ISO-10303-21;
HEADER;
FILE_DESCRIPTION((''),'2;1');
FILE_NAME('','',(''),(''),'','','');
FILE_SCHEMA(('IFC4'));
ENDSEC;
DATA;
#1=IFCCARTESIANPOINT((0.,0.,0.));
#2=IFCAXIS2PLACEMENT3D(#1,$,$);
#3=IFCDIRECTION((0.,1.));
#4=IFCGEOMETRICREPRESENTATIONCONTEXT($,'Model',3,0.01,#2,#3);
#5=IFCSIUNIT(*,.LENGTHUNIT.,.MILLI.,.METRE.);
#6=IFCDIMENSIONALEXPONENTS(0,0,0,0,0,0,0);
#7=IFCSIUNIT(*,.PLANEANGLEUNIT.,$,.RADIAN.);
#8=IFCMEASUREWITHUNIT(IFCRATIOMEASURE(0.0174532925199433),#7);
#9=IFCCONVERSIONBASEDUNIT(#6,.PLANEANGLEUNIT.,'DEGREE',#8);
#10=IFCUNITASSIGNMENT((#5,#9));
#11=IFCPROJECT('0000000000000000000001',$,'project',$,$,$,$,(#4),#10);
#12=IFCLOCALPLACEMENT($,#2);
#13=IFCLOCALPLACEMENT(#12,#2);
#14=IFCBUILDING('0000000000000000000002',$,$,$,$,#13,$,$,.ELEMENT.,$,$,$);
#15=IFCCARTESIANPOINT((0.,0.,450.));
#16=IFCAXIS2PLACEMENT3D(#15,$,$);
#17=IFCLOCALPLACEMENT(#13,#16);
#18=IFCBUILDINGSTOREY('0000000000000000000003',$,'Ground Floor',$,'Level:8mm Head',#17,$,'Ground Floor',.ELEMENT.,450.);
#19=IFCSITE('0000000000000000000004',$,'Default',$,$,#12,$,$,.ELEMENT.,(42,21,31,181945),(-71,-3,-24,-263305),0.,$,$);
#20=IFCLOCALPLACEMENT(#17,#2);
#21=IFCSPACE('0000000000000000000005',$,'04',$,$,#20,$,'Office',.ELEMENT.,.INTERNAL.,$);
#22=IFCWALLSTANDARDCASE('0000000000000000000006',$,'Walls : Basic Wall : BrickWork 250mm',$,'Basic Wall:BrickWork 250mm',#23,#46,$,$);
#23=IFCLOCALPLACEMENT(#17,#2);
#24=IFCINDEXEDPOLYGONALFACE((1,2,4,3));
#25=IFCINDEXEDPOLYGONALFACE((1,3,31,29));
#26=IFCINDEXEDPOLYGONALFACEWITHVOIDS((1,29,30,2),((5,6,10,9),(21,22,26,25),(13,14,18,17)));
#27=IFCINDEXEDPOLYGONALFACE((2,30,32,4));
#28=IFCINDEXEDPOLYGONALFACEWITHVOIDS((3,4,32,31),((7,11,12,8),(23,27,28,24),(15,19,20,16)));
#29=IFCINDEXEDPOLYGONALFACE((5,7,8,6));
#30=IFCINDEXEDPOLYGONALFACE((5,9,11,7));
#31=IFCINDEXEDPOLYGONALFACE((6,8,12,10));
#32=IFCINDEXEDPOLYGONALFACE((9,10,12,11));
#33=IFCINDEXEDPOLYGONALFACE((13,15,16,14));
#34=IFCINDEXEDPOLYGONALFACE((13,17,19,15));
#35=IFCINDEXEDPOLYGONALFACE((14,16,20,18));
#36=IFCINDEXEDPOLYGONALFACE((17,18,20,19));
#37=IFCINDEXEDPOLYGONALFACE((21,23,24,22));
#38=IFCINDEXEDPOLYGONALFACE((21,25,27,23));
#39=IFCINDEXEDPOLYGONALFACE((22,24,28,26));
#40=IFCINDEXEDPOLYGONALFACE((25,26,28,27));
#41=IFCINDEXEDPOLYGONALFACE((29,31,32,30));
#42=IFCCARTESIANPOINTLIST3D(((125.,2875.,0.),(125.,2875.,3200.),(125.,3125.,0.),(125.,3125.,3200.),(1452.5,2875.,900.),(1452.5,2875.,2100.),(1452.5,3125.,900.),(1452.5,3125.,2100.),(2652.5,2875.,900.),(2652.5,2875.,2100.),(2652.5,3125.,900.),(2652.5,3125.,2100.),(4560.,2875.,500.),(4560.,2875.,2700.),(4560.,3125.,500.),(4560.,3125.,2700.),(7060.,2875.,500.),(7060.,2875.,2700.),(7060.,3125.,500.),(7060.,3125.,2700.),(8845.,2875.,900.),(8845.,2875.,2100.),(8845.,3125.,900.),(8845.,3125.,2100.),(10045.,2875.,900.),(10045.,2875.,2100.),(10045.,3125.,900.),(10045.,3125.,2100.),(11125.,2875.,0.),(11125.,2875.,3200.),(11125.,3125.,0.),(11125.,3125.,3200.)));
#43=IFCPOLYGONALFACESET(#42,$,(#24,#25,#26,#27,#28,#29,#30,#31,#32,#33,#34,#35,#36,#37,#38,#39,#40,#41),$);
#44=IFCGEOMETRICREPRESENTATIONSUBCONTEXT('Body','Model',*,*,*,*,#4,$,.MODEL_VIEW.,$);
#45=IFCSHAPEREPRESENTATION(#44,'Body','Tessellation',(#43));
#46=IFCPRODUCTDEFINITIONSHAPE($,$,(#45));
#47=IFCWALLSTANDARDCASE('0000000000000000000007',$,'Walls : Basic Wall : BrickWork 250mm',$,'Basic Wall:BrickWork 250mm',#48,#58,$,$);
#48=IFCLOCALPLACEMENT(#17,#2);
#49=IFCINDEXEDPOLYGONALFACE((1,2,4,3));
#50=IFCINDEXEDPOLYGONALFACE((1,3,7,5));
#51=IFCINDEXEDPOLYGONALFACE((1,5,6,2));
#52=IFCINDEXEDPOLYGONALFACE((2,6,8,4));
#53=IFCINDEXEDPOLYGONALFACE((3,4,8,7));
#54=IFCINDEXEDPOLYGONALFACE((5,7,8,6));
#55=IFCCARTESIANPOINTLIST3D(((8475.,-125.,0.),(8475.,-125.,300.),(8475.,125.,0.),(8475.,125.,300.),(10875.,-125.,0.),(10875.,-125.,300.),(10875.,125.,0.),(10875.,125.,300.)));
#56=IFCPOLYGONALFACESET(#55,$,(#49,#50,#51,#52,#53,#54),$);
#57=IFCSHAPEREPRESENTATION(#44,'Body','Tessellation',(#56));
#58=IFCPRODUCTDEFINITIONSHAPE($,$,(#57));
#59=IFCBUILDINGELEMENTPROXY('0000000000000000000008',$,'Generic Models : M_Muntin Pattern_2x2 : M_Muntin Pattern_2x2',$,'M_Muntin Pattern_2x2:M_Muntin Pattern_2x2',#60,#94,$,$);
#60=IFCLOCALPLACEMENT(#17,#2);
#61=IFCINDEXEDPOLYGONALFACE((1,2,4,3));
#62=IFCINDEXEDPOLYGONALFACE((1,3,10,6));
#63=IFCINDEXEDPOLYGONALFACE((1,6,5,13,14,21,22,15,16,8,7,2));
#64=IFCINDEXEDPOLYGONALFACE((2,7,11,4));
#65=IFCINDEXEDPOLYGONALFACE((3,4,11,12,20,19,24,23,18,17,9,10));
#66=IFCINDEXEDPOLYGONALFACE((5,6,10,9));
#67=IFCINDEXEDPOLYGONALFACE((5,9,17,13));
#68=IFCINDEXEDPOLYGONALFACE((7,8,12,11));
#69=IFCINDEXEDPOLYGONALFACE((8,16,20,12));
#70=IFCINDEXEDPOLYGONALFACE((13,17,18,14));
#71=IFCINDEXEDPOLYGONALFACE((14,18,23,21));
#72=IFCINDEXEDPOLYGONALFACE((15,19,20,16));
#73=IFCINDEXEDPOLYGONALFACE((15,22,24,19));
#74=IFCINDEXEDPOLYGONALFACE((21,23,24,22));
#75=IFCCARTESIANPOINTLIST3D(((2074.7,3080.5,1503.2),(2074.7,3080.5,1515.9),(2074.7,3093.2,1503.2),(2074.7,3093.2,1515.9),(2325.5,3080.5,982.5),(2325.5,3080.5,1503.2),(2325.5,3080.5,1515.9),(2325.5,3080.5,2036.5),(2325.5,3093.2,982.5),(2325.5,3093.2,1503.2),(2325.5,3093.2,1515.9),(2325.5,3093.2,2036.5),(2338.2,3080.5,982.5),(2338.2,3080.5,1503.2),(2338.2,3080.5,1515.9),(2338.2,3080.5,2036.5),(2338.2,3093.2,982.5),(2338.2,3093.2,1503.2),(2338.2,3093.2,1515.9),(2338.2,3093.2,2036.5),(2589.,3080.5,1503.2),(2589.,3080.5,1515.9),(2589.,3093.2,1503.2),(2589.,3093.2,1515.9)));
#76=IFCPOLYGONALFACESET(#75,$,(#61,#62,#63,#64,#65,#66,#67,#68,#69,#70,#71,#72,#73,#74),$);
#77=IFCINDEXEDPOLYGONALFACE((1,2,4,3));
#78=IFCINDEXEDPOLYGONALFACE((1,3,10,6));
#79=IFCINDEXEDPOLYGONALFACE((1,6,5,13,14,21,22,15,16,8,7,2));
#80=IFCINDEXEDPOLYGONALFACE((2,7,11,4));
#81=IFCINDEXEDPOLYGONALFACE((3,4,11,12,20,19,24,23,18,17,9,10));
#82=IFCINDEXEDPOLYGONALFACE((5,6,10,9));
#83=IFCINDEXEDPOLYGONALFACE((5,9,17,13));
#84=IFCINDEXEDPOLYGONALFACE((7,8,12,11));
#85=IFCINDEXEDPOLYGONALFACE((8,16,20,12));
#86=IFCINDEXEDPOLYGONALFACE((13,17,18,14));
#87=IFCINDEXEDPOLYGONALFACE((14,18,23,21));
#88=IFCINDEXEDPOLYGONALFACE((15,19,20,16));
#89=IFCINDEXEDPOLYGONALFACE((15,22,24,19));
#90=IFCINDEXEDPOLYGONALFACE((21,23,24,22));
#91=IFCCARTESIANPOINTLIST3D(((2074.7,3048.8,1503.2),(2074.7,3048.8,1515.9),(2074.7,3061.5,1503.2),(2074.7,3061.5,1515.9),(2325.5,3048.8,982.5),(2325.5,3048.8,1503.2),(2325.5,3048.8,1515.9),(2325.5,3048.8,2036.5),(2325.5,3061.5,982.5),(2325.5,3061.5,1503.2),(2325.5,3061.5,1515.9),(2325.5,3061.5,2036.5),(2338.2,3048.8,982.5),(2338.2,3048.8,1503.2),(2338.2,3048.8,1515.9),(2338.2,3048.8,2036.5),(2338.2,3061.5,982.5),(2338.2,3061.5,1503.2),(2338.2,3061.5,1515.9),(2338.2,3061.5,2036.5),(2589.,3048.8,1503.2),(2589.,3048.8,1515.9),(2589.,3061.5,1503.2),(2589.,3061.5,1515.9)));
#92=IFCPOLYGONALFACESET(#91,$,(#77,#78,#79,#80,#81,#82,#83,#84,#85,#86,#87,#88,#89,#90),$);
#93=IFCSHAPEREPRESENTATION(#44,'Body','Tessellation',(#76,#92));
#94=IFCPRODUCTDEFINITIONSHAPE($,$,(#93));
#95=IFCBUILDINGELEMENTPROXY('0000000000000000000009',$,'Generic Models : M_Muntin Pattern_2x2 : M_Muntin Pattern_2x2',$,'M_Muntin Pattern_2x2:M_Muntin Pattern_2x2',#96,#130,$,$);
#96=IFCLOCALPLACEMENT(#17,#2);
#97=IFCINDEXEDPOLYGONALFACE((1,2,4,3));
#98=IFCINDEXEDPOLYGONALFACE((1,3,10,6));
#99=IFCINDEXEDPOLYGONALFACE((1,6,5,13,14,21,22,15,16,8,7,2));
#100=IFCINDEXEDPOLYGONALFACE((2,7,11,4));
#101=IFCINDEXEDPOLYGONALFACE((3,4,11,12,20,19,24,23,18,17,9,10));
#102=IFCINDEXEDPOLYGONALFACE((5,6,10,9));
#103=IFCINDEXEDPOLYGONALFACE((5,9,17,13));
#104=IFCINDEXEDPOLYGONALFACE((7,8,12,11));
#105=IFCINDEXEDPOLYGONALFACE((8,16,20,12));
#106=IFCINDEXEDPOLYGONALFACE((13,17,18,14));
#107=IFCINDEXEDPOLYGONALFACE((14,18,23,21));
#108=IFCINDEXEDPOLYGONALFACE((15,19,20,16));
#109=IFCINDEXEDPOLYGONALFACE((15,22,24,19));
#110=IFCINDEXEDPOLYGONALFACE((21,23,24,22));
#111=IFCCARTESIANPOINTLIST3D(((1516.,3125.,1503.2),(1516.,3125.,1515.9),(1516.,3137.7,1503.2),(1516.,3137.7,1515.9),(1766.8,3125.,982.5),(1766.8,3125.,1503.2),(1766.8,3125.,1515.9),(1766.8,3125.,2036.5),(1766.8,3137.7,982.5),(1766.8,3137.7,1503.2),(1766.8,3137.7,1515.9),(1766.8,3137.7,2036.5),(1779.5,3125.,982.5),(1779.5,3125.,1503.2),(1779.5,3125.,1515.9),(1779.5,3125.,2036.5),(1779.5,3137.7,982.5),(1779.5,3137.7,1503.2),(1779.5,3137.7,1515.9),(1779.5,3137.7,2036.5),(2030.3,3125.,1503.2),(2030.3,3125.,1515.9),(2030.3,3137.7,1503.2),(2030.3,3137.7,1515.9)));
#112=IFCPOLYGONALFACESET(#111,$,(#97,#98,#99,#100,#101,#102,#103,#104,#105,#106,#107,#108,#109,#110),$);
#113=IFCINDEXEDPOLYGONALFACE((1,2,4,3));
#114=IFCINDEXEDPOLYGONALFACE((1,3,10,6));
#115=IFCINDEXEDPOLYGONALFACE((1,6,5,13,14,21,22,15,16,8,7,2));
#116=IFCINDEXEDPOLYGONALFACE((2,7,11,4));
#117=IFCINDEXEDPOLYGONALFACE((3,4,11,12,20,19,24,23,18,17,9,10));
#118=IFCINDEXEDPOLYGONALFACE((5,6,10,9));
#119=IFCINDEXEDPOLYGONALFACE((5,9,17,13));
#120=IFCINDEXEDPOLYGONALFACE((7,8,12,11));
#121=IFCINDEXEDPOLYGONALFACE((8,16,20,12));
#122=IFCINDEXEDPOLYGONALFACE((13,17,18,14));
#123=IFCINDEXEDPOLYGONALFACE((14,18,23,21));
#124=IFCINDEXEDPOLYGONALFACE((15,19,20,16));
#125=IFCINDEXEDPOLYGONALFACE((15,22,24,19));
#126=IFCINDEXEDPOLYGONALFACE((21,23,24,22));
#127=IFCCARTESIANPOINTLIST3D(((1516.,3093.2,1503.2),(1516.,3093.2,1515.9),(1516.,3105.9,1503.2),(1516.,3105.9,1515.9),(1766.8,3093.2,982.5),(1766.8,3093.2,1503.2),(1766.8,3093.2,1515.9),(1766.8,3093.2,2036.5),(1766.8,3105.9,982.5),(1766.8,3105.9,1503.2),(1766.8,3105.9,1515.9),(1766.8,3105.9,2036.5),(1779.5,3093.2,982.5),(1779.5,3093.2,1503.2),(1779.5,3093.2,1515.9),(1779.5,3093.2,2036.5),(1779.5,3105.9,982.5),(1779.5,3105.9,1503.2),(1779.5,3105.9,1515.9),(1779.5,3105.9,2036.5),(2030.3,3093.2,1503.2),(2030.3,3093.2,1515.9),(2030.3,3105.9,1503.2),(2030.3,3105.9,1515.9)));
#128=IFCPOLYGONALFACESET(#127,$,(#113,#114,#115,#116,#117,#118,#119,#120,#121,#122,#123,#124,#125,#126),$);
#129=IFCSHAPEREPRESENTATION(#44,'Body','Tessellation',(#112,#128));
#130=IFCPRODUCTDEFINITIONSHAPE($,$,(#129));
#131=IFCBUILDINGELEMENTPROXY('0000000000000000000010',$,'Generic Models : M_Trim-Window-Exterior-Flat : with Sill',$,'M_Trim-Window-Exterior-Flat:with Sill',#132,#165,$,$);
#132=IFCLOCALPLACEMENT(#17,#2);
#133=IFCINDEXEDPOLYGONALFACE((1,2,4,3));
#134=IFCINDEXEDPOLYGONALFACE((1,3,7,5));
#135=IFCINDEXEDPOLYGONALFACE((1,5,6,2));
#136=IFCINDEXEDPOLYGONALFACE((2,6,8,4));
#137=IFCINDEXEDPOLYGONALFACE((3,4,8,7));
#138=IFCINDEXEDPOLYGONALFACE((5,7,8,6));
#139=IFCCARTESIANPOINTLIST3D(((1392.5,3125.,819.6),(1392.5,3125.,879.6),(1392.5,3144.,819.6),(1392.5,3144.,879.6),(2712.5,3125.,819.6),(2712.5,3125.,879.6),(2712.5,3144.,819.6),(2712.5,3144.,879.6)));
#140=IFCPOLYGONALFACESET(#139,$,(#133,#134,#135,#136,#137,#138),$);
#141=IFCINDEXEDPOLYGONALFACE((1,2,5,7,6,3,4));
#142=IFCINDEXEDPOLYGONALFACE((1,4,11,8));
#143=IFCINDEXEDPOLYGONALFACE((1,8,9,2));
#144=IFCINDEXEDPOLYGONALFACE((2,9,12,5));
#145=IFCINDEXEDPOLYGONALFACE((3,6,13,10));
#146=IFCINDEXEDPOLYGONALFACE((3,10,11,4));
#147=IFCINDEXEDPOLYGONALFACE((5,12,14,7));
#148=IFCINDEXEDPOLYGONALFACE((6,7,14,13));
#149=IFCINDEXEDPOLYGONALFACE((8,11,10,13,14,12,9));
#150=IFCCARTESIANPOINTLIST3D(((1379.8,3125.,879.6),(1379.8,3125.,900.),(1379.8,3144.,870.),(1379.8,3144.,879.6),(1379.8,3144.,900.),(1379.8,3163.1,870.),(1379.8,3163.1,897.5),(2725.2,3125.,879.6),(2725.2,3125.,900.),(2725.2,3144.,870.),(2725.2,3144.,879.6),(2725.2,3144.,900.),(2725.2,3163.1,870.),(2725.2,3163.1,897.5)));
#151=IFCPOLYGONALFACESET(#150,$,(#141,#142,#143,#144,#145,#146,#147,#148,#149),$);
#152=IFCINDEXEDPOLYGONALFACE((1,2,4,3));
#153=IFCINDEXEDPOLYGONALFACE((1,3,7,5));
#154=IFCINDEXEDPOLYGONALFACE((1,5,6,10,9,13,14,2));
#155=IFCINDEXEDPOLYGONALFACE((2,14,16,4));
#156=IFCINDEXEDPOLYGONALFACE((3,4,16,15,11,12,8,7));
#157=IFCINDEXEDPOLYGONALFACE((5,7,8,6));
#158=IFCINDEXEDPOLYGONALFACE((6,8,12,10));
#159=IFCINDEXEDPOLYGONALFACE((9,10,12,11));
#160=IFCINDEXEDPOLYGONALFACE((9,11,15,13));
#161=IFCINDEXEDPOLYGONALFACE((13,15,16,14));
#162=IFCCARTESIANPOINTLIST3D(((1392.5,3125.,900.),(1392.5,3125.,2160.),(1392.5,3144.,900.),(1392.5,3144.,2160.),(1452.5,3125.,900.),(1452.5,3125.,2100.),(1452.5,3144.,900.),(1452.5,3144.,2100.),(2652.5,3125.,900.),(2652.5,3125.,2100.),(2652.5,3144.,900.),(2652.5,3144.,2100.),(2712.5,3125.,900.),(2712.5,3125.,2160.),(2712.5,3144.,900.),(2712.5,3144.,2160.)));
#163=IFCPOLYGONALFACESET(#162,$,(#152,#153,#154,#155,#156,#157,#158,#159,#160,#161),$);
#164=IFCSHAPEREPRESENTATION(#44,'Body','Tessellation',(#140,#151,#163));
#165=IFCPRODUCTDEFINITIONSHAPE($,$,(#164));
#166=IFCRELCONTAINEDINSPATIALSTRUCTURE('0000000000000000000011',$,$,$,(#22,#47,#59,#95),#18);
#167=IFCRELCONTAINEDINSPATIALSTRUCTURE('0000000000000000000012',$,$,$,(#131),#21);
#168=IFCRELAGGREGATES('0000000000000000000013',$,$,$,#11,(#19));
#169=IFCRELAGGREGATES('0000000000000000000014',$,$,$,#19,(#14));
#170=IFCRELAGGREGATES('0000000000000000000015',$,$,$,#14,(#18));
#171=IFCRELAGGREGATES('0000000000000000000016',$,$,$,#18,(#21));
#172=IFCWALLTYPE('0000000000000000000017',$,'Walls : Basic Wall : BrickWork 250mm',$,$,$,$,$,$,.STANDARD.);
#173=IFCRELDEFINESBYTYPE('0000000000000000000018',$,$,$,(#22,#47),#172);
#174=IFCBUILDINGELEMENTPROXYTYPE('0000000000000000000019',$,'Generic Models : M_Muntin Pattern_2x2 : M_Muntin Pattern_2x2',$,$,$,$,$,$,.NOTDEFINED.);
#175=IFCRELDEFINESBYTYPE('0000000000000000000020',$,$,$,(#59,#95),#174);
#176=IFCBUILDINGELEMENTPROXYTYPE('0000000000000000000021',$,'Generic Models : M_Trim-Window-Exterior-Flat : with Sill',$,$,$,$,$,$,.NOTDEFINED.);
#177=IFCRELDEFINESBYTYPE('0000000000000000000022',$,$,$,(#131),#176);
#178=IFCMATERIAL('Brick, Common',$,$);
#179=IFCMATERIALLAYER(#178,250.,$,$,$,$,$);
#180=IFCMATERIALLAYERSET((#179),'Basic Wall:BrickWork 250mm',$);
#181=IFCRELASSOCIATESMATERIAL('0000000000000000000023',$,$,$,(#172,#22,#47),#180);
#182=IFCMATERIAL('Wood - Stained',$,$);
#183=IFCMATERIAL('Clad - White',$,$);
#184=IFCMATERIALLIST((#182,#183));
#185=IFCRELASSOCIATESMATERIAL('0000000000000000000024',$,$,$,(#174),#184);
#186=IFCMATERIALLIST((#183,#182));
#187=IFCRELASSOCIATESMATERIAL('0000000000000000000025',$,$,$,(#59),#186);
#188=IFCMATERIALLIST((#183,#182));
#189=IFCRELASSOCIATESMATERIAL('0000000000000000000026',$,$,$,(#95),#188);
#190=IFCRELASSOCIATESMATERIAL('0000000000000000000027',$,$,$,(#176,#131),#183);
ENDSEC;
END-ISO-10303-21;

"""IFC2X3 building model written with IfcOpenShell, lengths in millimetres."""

from ifc_helpers import new_model, entity, si_unit, converted_unit, direction, frame, frame_2d, origin, place, context, subcontext, project, spatial, polyline, rectangle, outline, extrude, clip, halfspace, source, transform, mapped, material, material_list, layer, layer_set, layer_usage, type_object, type_shapes, element, save


model = new_model("IFC2X3")

# Units and contexts
model_context = context("Model", 3, precision=0.01, world=origin(), true_north=direction((0.0, 1.0)))
body_context = subcontext(model_context, "Body", "Model", "MODEL_VIEW")
ifc_project = project(units=[si_unit("LENGTHUNIT", "METRE", prefix="MILLI"), converted_unit("PLANEANGLEUNIT", "DEGREE", entity("IfcRatioMeasure", 0.0174532925199433), si_unit("PLANEANGLEUNIT", "RADIAN"), dimensions=[0, 0, 0, 0, 0, 0, 0])], contexts=[model_context])

# Site, building, storey
site_placement = place(None, origin())
site = spatial("IfcSite", under=ifc_project, at=site_placement, Name="Default", CompositionType="ELEMENT", RefLatitude=(42, 21, 31, 181945), RefLongitude=(-71, -3, -24, -263305), RefElevation=0.0)
building_placement = place(site_placement, origin())
building = spatial("IfcBuilding", under=site, at=building_placement, CompositionType="ELEMENT")
storey_placement = place(building_placement, frame((0.0, 0.0, 450.0)))
storey = spatial("IfcBuildingStorey", under=building, at=storey_placement, Name="Ground Floor", ObjectType="Level:8mm Head", LongName="Ground Floor", CompositionType="ELEMENT", Elevation=450.0)

# Shared definitions
ifc_material_1 = material(Name="Brick, Common")
ifc_layer = layer(ifc_material_1, 250.0)
ifc_layer_set = layer_set([ifc_layer], Name="Basic Wall:BrickWork 250mm")
wall_type = type_object("IfcWallType", Name="Walls : Basic Wall : BrickWork 250mm", PredefinedType="STANDARD", material=ifc_layer_set)

# Wall, openings
ifc_layer_usage_1 = layer_usage(ifc_layer_set, "AXIS2", "POSITIVE", -125.0)
wall_1_placement = place(storey_placement, frame((125.0, 3000.0, 0.0)))
wall_1 = element("IfcWallStandardCase", 1, at=wall_1_placement, inside=storey, type_object=wall_type, material=ifc_layer_usage_1, Name="Walls : Basic Wall : BrickWork 250mm", ObjectType="Basic Wall:BrickWork 250mm", context=body_context, shape_type="Clipping", body=[
    clip(extrude(rectangle(XDim=11000.0, YDim=250.0, at=frame_2d((5500.0, 0.0), x_axis=(-1.0, 0.0))), origin(), (0.0, 0.0, 1.0), 3200.0), halfspace(origin(), True)),
])
opening_1_placement = place(wall_1_placement, origin())
element("IfcOpeningElement", 2, at=opening_1_placement, cuts=wall_1, ObjectType="Opening", context=body_context, shape_type="SweptSolid", body=[
    extrude(rectangle(XDim=2200.0, YDim=2500.0, at=frame_2d((0.0, 0.0), x_axis=(1.0, 0.0))), frame((5685.0, -277.4, 1600.0), z_axis=(0.0, 1.0, 0.0), x_axis=(0.0, 0.0, 1.0)), (0.0, 0.0, 1.0), 554.8),
])
opening_2_placement = place(wall_1_placement, frame((1327.5, -125.0, 900.0)))
element("IfcOpeningElement", 3, at=opening_2_placement, cuts=wall_1, ObjectType="Opening", context=body_context, shape_type="SweptSolid", body=[
    extrude(rectangle(XDim=1200.0, YDim=1200.0, at=frame_2d((600.0, 600.0), x_axis=(-1.0, 0.0))), frame((0.0, 0.0, 0.0), z_axis=(0.0, 1.0, 0.0), x_axis=(0.0, 0.0, 1.0)), (0.0, 0.0, 1.0), 250.0),
])
opening_3_placement = place(wall_1_placement, frame((8720.0, -125.0, 900.0)))
element("IfcOpeningElement", 4, at=opening_3_placement, cuts=wall_1, ObjectType="Opening", context=body_context, shape_type="SweptSolid", body=[
    extrude(rectangle(XDim=1200.0, YDim=1200.0, at=frame_2d((600.0, 600.0), x_axis=(-1.0, 0.0))), frame((0.0, 0.0, 0.0), z_axis=(0.0, 1.0, 0.0), x_axis=(0.0, 0.0, 1.0)), (0.0, 0.0, 1.0), 250.0),
])

# Wall
ifc_layer_usage_2 = layer_usage(ifc_layer_set, "AXIS2", "NEGATIVE", 125.0)
wall_2_placement = place(storey_placement, frame((8475.0, 0.0, 0.0)))
element("IfcWallStandardCase", 5, at=wall_2_placement, inside=storey, type_object=wall_type, material=ifc_layer_usage_2, Name="Walls : Basic Wall : BrickWork 250mm", ObjectType="Basic Wall:BrickWork 250mm", context=body_context, shape_type="Clipping", body=[
    clip(extrude(rectangle(XDim=2400.0, YDim=250.0, at=frame_2d((1200.0, 0.0), x_axis=(-1.0, 0.0))), origin(), (0.0, 0.0, 1.0), 300.0), halfspace(frame((0.0, 0.0, -450.0)), True)),
])

# Building element proxies
ifc_material_2 = material(Name="Clad - White")
ifc_material_3 = material(Name="Wood - Stained")
ifc_material_list_1 = material_list([ifc_material_2, ifc_material_3])
ifc_material_list_2 = material_list([ifc_material_3, ifc_material_2])
building_element_proxy_type_1 = type_object("IfcBuildingElementProxyType", Name="Generic Models : M_Muntin Pattern_2x2 : M_Muntin Pattern_2x2", PredefinedType="NOTDEFINED", material=ifc_material_list_2)
shared_shape_1 = source(origin(), body_context, "Body", "SweptSolid", [
    extrude(outline(polyline([(6.4, -6.4), (527.0, -6.4), (527.0, 6.3), (6.4, 6.3), (6.4, 257.1), (-6.3, 257.1), (-6.3, 6.3), (-527.0, 6.3), (-527.0, -6.4), (-6.3, -6.4), (-6.3, -257.1), (6.4, -257.1), (6.4, -6.4)])), frame((0.0, 9.5, 527.0), z_axis=(0.0, 1.0, 0.0), x_axis=(0.0, 0.0, 1.0)), (0.0, 0.0, 1.0), 12.7),
    extrude(outline(polyline([(6.4, -6.4), (527.0, -6.4), (527.0, 6.3), (6.4, 6.3), (6.4, 257.1), (-6.3, 257.1), (-6.3, 6.3), (-527.0, 6.3), (-527.0, -6.4), (-6.3, -6.4), (-6.3, -257.1), (6.4, -257.1), (6.4, -6.4)])), frame((0.0, -22.2, 527.0), z_axis=(0.0, 1.0, 0.0), x_axis=(0.0, 0.0, 1.0)), (0.0, 0.0, 1.0), 12.7),
])
type_shapes(building_element_proxy_type_1, [shared_shape_1])
proxy_1_placement = place(storey_placement, frame((2331.9, 3071.0, 982.5)))
element("IfcBuildingElementProxy", 6, at=proxy_1_placement, inside=storey, type_object=building_element_proxy_type_1, material=ifc_material_list_1, Name="Generic Models : M_Muntin Pattern_2x2 : M_Muntin Pattern_2x2", ObjectType="M_Muntin Pattern_2x2:M_Muntin Pattern_2x2", context=body_context, shape_type="MappedRepresentation", body=[
    mapped(shared_shape_1, transform((0.0, 0.0, 0.0), scale=1.0)),
])
ifc_material_list_3 = material_list([ifc_material_2, ifc_material_3])
proxy_2_placement = place(storey_placement, frame((1773.1, 3115.5, 982.5)))
element("IfcBuildingElementProxy", 7, at=proxy_2_placement, inside=storey, type_object=building_element_proxy_type_1, material=ifc_material_list_3, Name="Generic Models : M_Muntin Pattern_2x2 : M_Muntin Pattern_2x2", ObjectType="M_Muntin Pattern_2x2:M_Muntin Pattern_2x2", context=body_context, shape_type="MappedRepresentation", body=[
    mapped(shared_shape_1, transform((0.0, 0.0, 0.0), scale=1.0)),
])

# Shared definitions
space_placement = place(storey_placement, origin())
space = spatial("IfcSpace", under=storey, at=space_placement, Name="04", LongName="Office", CompositionType="ELEMENT", InteriorOrExteriorSpace="INTERNAL")

# Building element proxy
building_element_proxy_type_2 = type_object("IfcBuildingElementProxyType", Name="Generic Models : M_Trim-Window-Exterior-Flat : with Sill", PredefinedType="NOTDEFINED", material=ifc_material_2)
shared_shape_2 = source(origin(), body_context, "Body", "SweptSolid", [
    extrude(rectangle(XDim=1320.0, YDim=60.0, at=frame_2d((0.0, 0.0), x_axis=(1.0, 0.0))), frame((0.0, -1250.4, 0.0), z_axis=(0.0, 0.0, 1.0), x_axis=(-1.0, 0.0, 0.0)), (0.0, 0.0, 1.0), 19.1),
    extrude(outline(polyline([(-19.0, -15.2), (0.0, -15.2), (0.0, -5.7), (19.0, -5.7), (19.0, 14.8), (0.0, 14.8), (-19.0, 12.3), (-19.0, -15.2)])), frame((-672.7, -1214.8, 19.0), z_axis=(1.0, 0.0, 0.0), x_axis=(0.0, 0.0, -1.0)), (0.0, 0.0, 1.0), 1345.4),
    extrude(outline(polyline([(-645.0, -660.0), (615.0, -660.0), (615.0, -600.0), (-585.0, -600.0), (-585.0, 600.0), (615.0, 600.0), (615.0, 660.0), (-645.0, 660.0), (-645.0, -660.0)])), frame((0.0, -585.0, 0.0), z_axis=(0.0, 0.0, 1.0), x_axis=(0.0, -1.0, 0.0)), (0.0, 0.0, 1.0), 19.1),
])
type_shapes(building_element_proxy_type_2, [shared_shape_2])
proxy_3_placement = place(space_placement, frame((2052.5, 3125.0, 2100.0), z_axis=(0.0, 1.0, 0.0), x_axis=(-1.0, 0.0, 0.0)))
element("IfcBuildingElementProxy", 8, at=proxy_3_placement, inside=space, type_object=building_element_proxy_type_2, material=ifc_material_2, Name="Generic Models : M_Trim-Window-Exterior-Flat : with Sill", ObjectType="M_Trim-Window-Exterior-Flat:with Sill", context=body_context, shape_type="MappedRepresentation", body=[
    mapped(shared_shape_2, transform((0.0, 0.0, 0.0), scale=1.0)),
])

save(model, "model.ifc")
